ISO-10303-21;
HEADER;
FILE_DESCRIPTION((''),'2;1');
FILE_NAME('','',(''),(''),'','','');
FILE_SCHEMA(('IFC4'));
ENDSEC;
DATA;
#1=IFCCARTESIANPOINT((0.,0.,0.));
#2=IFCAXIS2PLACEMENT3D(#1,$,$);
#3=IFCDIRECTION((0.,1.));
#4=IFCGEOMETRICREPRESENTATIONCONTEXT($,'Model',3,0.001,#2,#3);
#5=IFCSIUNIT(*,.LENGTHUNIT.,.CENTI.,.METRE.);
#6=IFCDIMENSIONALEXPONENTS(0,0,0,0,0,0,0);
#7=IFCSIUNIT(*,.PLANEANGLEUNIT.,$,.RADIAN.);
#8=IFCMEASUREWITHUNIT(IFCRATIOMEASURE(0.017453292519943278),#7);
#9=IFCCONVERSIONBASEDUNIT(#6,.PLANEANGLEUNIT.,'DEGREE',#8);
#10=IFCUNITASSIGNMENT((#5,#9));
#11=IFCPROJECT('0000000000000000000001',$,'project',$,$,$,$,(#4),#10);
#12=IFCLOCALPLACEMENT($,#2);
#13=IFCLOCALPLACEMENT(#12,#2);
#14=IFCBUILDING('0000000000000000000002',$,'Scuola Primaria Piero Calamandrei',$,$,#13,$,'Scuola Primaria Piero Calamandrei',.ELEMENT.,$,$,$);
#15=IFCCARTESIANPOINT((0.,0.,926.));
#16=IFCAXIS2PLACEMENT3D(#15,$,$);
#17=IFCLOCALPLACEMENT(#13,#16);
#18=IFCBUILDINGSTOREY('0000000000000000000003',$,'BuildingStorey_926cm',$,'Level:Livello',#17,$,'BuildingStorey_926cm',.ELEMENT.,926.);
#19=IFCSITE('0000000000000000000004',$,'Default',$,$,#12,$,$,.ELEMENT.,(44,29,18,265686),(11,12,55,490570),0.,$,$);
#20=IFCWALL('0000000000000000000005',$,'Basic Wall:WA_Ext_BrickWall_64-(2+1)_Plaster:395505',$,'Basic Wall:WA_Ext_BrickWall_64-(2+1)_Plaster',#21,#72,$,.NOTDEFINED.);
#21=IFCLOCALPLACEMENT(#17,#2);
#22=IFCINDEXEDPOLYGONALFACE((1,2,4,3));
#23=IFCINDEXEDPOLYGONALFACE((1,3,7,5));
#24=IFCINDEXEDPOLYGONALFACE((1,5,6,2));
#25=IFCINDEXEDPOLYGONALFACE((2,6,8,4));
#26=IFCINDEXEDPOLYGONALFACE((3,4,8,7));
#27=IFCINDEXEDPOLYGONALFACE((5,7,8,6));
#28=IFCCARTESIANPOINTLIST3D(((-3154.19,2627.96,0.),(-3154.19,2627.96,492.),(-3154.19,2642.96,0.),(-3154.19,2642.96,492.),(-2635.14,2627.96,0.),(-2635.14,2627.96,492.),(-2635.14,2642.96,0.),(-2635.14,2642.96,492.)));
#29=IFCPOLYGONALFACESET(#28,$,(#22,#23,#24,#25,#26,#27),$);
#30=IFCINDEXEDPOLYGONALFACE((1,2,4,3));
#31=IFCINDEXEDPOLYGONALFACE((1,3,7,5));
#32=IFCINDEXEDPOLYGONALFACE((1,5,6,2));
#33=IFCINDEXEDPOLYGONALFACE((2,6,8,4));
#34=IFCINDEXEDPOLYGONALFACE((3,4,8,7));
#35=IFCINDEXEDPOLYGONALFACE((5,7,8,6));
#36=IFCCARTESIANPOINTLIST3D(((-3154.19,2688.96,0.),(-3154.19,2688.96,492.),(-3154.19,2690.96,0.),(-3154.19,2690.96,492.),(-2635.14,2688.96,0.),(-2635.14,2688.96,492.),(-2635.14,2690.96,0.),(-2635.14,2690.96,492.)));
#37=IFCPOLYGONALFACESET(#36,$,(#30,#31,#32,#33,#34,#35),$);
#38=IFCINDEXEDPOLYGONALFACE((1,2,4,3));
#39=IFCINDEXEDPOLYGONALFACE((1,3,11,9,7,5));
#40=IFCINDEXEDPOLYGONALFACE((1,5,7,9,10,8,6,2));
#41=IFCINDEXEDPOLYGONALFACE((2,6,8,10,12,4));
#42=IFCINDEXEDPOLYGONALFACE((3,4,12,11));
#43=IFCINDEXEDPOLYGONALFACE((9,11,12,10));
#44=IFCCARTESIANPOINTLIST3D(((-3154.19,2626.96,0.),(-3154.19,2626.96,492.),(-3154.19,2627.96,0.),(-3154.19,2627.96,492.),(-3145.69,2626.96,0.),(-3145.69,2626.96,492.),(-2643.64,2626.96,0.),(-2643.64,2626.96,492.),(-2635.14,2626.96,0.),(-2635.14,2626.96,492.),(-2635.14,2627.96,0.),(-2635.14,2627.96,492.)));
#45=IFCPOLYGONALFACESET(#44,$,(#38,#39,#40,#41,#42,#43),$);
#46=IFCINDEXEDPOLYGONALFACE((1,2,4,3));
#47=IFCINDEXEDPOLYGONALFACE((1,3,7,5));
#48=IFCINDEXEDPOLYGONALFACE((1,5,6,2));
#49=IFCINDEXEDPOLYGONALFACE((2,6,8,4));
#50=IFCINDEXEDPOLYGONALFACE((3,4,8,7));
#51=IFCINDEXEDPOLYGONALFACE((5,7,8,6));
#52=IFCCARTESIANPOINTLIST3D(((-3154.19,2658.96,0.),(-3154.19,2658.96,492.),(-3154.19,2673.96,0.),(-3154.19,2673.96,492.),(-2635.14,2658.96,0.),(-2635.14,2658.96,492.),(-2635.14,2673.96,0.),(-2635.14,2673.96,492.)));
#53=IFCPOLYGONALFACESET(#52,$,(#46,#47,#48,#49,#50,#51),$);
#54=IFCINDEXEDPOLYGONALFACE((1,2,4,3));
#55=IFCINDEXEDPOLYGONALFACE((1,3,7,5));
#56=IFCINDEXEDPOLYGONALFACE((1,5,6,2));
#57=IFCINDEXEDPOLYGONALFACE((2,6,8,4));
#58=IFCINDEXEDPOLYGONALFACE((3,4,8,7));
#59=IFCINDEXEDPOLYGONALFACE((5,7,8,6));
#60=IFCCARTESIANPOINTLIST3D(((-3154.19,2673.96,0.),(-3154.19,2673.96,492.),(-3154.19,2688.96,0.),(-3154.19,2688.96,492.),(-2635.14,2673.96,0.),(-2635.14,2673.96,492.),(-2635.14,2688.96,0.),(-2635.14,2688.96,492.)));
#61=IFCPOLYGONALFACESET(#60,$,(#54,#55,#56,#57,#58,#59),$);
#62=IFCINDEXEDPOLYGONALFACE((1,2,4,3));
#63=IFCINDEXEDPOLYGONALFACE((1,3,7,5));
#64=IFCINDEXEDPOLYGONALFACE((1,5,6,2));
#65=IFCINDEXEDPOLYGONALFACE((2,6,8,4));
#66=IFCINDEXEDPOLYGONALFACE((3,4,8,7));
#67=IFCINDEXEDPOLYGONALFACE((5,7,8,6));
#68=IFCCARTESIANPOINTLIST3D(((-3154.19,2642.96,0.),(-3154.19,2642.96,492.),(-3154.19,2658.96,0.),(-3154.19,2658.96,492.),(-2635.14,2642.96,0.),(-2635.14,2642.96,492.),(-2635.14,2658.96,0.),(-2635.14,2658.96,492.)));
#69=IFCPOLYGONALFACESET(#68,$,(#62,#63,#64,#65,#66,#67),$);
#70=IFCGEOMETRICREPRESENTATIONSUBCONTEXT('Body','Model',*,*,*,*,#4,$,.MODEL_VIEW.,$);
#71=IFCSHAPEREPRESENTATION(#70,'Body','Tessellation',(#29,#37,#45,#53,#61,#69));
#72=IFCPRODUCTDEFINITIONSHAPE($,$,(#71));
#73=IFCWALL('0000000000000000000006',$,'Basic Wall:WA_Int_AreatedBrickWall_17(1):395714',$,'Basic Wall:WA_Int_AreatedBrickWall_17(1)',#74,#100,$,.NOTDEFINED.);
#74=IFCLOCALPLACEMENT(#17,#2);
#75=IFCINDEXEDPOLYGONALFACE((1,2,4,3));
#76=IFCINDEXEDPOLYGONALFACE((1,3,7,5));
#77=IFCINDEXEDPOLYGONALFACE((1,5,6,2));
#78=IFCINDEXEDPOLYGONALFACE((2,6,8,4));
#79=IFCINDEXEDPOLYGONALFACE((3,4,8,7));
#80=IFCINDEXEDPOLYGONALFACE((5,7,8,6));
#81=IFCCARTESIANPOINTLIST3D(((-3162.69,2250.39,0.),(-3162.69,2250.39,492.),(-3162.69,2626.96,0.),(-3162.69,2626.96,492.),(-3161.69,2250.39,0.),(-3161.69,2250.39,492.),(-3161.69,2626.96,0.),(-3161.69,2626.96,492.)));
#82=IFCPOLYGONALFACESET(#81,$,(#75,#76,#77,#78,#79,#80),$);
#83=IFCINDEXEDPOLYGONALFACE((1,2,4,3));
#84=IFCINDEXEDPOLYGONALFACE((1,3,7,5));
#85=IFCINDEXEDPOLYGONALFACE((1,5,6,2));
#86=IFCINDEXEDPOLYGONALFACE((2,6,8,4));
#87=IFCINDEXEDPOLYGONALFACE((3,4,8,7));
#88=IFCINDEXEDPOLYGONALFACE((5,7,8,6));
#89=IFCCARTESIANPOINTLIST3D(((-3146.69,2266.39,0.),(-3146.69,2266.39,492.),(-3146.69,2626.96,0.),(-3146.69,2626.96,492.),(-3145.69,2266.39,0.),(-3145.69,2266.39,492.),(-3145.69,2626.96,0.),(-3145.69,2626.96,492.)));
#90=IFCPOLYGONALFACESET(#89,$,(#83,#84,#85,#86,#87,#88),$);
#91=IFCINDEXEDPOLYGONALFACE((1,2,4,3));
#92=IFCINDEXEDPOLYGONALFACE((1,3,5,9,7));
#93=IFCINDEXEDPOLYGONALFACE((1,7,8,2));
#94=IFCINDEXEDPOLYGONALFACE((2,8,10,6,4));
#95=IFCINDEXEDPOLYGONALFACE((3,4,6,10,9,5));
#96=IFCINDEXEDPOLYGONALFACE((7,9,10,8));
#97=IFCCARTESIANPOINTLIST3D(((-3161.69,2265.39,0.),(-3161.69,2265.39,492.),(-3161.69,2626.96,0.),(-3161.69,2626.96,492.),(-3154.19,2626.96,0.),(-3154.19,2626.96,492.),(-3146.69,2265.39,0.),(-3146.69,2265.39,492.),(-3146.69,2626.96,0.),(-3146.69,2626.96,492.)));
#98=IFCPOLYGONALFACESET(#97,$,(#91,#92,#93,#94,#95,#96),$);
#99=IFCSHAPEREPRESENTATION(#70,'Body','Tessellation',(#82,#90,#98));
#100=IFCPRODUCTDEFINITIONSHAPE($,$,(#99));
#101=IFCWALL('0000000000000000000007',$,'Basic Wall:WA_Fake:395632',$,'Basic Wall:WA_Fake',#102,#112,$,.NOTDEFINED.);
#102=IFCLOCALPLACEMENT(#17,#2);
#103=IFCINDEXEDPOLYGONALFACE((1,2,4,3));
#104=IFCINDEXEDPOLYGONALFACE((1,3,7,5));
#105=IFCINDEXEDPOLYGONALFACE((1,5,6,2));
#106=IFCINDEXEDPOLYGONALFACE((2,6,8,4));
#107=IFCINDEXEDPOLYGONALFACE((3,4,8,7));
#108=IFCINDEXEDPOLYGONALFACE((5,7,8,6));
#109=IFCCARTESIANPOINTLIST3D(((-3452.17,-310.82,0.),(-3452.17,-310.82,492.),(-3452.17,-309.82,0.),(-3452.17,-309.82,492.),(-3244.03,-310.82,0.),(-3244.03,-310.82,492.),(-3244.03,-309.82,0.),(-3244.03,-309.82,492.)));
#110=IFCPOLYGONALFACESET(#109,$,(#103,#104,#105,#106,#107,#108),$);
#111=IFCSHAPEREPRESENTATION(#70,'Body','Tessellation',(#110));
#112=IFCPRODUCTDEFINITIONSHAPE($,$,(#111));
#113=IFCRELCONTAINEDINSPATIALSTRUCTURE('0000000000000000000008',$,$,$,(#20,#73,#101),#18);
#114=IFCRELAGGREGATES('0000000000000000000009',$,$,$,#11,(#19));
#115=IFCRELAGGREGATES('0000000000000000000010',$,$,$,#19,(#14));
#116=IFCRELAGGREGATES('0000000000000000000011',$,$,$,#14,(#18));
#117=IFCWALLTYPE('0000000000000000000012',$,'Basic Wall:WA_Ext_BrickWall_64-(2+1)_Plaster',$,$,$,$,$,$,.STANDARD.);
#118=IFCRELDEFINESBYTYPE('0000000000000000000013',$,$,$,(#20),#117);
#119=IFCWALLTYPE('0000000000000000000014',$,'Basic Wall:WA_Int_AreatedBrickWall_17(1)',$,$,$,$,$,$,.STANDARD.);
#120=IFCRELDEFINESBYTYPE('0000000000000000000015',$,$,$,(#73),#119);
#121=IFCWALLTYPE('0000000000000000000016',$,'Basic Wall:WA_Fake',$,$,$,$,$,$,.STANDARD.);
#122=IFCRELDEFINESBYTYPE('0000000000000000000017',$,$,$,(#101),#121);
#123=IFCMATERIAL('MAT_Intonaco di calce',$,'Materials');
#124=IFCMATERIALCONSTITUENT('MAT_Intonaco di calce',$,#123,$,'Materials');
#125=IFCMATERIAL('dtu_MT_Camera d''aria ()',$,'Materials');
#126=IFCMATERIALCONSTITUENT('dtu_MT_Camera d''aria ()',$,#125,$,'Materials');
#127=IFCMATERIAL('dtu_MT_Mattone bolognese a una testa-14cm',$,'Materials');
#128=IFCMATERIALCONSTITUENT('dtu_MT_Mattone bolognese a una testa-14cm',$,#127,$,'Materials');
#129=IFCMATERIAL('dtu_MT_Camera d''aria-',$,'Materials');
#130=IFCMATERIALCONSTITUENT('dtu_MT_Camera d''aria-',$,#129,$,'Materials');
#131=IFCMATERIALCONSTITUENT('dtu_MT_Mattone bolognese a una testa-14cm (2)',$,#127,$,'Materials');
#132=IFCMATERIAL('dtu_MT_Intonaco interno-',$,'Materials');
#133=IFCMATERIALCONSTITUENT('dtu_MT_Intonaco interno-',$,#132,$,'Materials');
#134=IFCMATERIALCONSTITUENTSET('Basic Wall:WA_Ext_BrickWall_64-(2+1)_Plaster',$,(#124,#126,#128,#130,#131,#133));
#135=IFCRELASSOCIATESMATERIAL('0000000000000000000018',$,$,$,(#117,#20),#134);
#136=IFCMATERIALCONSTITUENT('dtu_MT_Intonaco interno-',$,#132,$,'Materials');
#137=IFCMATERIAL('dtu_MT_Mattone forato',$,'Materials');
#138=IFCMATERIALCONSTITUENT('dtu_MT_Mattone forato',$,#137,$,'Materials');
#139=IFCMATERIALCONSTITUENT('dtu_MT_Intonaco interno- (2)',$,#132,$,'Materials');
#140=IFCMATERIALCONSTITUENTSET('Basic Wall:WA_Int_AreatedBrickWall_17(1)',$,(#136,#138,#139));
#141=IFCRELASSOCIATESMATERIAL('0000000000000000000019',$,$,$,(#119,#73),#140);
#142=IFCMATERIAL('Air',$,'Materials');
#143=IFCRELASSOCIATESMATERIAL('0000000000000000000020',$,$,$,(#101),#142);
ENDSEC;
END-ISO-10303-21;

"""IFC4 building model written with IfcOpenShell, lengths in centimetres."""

from ifc_helpers import new_model, entity, si_unit, converted_unit, direction, frame, origin, place, context, subcontext, project, spatial, indexed_curve, outline, extrude, material, constituent, constituent_set, type_object, element, save


model = new_model("IFC4")

# Units and contexts
model_context = context("Model", 3, precision=0.001, world=origin(), true_north=direction((0.0, 1.0)))
body_context = subcontext(model_context, "Body", "Model", "MODEL_VIEW")
ifc_project = project(units=[si_unit("LENGTHUNIT", "METRE", prefix="CENTI"), converted_unit("PLANEANGLEUNIT", "DEGREE", entity("IfcRatioMeasure", 0.017453292519943278), si_unit("PLANEANGLEUNIT", "RADIAN"), dimensions=[0, 0, 0, 0, 0, 0, 0])], contexts=[model_context])

# Site, building, storey
site_placement = place(None, origin())
site = spatial("IfcSite", under=ifc_project, at=site_placement, Name="Default", CompositionType="ELEMENT", RefLatitude=(44, 29, 18, 265686), RefLongitude=(11, 12, 55, 490570), RefElevation=0.0)
building_placement = place(site_placement, origin())
building = spatial("IfcBuilding", under=site, at=building_placement, Name="Scuola Primaria Piero Calamandrei", LongName="Scuola Primaria Piero Calamandrei", CompositionType="ELEMENT")
storey_placement = place(building_placement, frame((0.0, 0.0, 926.0)))
storey = spatial("IfcBuildingStorey", under=building, at=storey_placement, Name="BuildingStorey_926cm", ObjectType="Level:Livello", LongName="BuildingStorey_926cm", CompositionType="ELEMENT", Elevation=926.0)

# Wall
ifc_material_1 = material(Name="MAT_Intonaco di calce", Category="Materials")
ifc_constituent_1 = constituent(ifc_material_1, Name="MAT_Intonaco di calce", Category="Materials")
ifc_material_2 = material(Name="dtu_MT_Camera d'aria ()", Category="Materials")
ifc_constituent_2 = constituent(ifc_material_2, Name="dtu_MT_Camera d'aria ()", Category="Materials")
ifc_material_3 = material(Name="dtu_MT_Mattone bolognese a una testa-14cm", Category="Materials")
ifc_constituent_3 = constituent(ifc_material_3, Name="dtu_MT_Mattone bolognese a una testa-14cm", Category="Materials")
ifc_material_4 = material(Name="dtu_MT_Camera d'aria-", Category="Materials")
ifc_constituent_4 = constituent(ifc_material_4, Name="dtu_MT_Camera d'aria-", Category="Materials")
ifc_constituent_5 = constituent(ifc_material_3, Name="dtu_MT_Mattone bolognese a una testa-14cm (2)", Category="Materials")
ifc_material_5 = material(Name="dtu_MT_Intonaco interno-", Category="Materials")
ifc_constituent_6 = constituent(ifc_material_5, Name="dtu_MT_Intonaco interno-", Category="Materials")
ifc_constituent_set_1 = constituent_set(constituents=[ifc_constituent_1, ifc_constituent_2, ifc_constituent_3, ifc_constituent_4, ifc_constituent_5, ifc_constituent_6], Name="Basic Wall:WA_Ext_BrickWall_64-(2+1)_Plaster")
wall_type_1 = type_object("IfcWallType", Name="Basic Wall:WA_Ext_BrickWall_64-(2+1)_Plaster", PredefinedType="STANDARD", material=ifc_constituent_set_1)
wall_1_placement = place(storey_placement, frame((-3154.19, 2658.96, 0.0)))
element("IfcWall", 1, at=wall_1_placement, inside=storey, type_object=wall_type_1, material=ifc_constituent_set_1, Name="Basic Wall:WA_Ext_BrickWall_64-(2+1)_Plaster:395505", ObjectType="Basic Wall:WA_Ext_BrickWall_64-(2+1)_Plaster", PredefinedType="NOTDEFINED", context=body_context, shape_type="SweptSolid", body=[
    extrude(outline(indexed_curve([(-259.53, -7.5), (259.53, -7.5), (259.53, 7.5), (-259.53, 7.5), (-259.53, -7.5)], self_intersect=False)), frame((259.53, -23.5, 0.0)), (0.0, 0.0, 1.0), 492.0),
    extrude(outline(indexed_curve([(-1.0, -259.53), (1.0, -259.53), (1.0, 259.53), (-1.0, 259.53), (-1.0, -259.53)], self_intersect=False)), frame((259.53, 31.0, 0.0), z_axis=(0.0, 0.0, 1.0), x_axis=(0.0, -1.0, 0.0)), (0.0, 0.0, 1.0), 492.0),
    extrude(outline(indexed_curve([(-251.03, -0.33), (251.03, -0.33), (259.53, -0.33), (259.53, 0.67), (-259.53, 0.67), (-259.53, -0.33), (-251.03, -0.33)], self_intersect=False)), frame((259.53, -31.67, 0.0)), (0.0, 0.0, 1.0), 492.0),
    extrude(outline(indexed_curve([(-259.53, -7.5), (259.53, -7.5), (259.53, 7.5), (-259.53, 7.5), (-259.53, -7.5)], self_intersect=False)), frame((259.53, 7.5, 0.0)), (0.0, 0.0, 1.0), 492.0),
    extrude(outline(indexed_curve([(-259.53, -7.5), (259.53, -7.5), (259.53, 7.5), (-259.53, 7.5), (-259.53, -7.5)], self_intersect=False)), frame((259.53, 22.5, 0.0)), (0.0, 0.0, 1.0), 492.0),
    extrude(outline(indexed_curve([(-259.53, -8.0), (259.53, -8.0), (259.53, 8.0), (-259.53, 8.0), (-259.53, -8.0)], self_intersect=False)), frame((259.53, -8.0, 0.0)), (0.0, 0.0, 1.0), 492.0),
])

# Shared definitions
ifc_constituent_7 = constituent(ifc_material_5, Name="dtu_MT_Intonaco interno-", Category="Materials")
ifc_material_6 = material(Name="dtu_MT_Mattone forato", Category="Materials")
ifc_constituent_8 = constituent(ifc_material_6, Name="dtu_MT_Mattone forato", Category="Materials")
ifc_constituent_9 = constituent(ifc_material_5, Name="dtu_MT_Intonaco interno- (2)", Category="Materials")
ifc_constituent_set_2 = constituent_set(constituents=[ifc_constituent_7, ifc_constituent_8, ifc_constituent_9], Name="Basic Wall:WA_Int_AreatedBrickWall_17(1)")
wall_type_2 = type_object("IfcWallType", Name="Basic Wall:WA_Int_AreatedBrickWall_17(1)", PredefinedType="STANDARD", material=ifc_constituent_set_2)

# Walls
wall_2_placement = place(storey_placement, frame((-3154.19, 2626.96, 0.0), z_axis=(0.0, 0.0, 1.0), x_axis=(0.0, -1.0, 0.0)))
element("IfcWall", 2, at=wall_2_placement, inside=storey, type_object=wall_type_2, material=ifc_constituent_set_2, Name="Basic Wall:WA_Int_AreatedBrickWall_17(1):395714", ObjectType="Basic Wall:WA_Int_AreatedBrickWall_17(1)", PredefinedType="NOTDEFINED", context=body_context, shape_type="SweptSolid", body=[
    extrude(outline(indexed_curve([(-0.5, -188.29), (0.5, -188.29), (0.5, 188.29), (-0.5, 188.29), (-0.5, -188.29)], self_intersect=False)), frame((188.29, -8.0, 0.0), z_axis=(0.0, 0.0, 1.0), x_axis=(0.0, 1.0, 0.0)), (0.0, 0.0, 1.0), 492.0),
    extrude(outline(indexed_curve([(-0.5, -180.29), (0.5, -180.29), (0.5, 180.29), (-0.5, 180.29), (-0.5, -180.29)], self_intersect=False)), frame((180.29, 8.0, 0.0), z_axis=(0.0, 0.0, 1.0), x_axis=(0.0, -1.0, 0.0)), (0.0, 0.0, 1.0), 492.0),
    extrude(outline(indexed_curve([(-144.63, -7.5), (216.94, -7.5), (216.94, 7.5), (-144.63, 7.5), (-144.63, 0.0), (-144.63, -7.5)], self_intersect=False)), frame((144.63, 0.0, 0.0)), (0.0, 0.0, 1.0), 492.0),
])
ifc_material_7 = material(Name="Air", Category="Materials")
wall_type_3 = type_object("IfcWallType", Name="Basic Wall:WA_Fake", PredefinedType="STANDARD")
wall_3_placement = place(storey_placement, frame((-3244.03, -310.32, 0.0), z_axis=(0.0, 0.0, 1.0), x_axis=(-1.0, 0.0, 0.0)))
element("IfcWall", 3, at=wall_3_placement, inside=storey, type_object=wall_type_3, material=ifc_material_7, Name="Basic Wall:WA_Fake:395632", ObjectType="Basic Wall:WA_Fake", PredefinedType="NOTDEFINED", context=body_context, shape_type="SweptSolid", body=[
    extrude(outline(indexed_curve([(208.14, 0.5), (0.0, 0.5), (0.0, -0.5), (208.14, -0.5), (208.14, 0.5)], self_intersect=False)), origin(), (0.0, 0.0, 1.0), 492.0),
])

save(model, "model.ifc")
